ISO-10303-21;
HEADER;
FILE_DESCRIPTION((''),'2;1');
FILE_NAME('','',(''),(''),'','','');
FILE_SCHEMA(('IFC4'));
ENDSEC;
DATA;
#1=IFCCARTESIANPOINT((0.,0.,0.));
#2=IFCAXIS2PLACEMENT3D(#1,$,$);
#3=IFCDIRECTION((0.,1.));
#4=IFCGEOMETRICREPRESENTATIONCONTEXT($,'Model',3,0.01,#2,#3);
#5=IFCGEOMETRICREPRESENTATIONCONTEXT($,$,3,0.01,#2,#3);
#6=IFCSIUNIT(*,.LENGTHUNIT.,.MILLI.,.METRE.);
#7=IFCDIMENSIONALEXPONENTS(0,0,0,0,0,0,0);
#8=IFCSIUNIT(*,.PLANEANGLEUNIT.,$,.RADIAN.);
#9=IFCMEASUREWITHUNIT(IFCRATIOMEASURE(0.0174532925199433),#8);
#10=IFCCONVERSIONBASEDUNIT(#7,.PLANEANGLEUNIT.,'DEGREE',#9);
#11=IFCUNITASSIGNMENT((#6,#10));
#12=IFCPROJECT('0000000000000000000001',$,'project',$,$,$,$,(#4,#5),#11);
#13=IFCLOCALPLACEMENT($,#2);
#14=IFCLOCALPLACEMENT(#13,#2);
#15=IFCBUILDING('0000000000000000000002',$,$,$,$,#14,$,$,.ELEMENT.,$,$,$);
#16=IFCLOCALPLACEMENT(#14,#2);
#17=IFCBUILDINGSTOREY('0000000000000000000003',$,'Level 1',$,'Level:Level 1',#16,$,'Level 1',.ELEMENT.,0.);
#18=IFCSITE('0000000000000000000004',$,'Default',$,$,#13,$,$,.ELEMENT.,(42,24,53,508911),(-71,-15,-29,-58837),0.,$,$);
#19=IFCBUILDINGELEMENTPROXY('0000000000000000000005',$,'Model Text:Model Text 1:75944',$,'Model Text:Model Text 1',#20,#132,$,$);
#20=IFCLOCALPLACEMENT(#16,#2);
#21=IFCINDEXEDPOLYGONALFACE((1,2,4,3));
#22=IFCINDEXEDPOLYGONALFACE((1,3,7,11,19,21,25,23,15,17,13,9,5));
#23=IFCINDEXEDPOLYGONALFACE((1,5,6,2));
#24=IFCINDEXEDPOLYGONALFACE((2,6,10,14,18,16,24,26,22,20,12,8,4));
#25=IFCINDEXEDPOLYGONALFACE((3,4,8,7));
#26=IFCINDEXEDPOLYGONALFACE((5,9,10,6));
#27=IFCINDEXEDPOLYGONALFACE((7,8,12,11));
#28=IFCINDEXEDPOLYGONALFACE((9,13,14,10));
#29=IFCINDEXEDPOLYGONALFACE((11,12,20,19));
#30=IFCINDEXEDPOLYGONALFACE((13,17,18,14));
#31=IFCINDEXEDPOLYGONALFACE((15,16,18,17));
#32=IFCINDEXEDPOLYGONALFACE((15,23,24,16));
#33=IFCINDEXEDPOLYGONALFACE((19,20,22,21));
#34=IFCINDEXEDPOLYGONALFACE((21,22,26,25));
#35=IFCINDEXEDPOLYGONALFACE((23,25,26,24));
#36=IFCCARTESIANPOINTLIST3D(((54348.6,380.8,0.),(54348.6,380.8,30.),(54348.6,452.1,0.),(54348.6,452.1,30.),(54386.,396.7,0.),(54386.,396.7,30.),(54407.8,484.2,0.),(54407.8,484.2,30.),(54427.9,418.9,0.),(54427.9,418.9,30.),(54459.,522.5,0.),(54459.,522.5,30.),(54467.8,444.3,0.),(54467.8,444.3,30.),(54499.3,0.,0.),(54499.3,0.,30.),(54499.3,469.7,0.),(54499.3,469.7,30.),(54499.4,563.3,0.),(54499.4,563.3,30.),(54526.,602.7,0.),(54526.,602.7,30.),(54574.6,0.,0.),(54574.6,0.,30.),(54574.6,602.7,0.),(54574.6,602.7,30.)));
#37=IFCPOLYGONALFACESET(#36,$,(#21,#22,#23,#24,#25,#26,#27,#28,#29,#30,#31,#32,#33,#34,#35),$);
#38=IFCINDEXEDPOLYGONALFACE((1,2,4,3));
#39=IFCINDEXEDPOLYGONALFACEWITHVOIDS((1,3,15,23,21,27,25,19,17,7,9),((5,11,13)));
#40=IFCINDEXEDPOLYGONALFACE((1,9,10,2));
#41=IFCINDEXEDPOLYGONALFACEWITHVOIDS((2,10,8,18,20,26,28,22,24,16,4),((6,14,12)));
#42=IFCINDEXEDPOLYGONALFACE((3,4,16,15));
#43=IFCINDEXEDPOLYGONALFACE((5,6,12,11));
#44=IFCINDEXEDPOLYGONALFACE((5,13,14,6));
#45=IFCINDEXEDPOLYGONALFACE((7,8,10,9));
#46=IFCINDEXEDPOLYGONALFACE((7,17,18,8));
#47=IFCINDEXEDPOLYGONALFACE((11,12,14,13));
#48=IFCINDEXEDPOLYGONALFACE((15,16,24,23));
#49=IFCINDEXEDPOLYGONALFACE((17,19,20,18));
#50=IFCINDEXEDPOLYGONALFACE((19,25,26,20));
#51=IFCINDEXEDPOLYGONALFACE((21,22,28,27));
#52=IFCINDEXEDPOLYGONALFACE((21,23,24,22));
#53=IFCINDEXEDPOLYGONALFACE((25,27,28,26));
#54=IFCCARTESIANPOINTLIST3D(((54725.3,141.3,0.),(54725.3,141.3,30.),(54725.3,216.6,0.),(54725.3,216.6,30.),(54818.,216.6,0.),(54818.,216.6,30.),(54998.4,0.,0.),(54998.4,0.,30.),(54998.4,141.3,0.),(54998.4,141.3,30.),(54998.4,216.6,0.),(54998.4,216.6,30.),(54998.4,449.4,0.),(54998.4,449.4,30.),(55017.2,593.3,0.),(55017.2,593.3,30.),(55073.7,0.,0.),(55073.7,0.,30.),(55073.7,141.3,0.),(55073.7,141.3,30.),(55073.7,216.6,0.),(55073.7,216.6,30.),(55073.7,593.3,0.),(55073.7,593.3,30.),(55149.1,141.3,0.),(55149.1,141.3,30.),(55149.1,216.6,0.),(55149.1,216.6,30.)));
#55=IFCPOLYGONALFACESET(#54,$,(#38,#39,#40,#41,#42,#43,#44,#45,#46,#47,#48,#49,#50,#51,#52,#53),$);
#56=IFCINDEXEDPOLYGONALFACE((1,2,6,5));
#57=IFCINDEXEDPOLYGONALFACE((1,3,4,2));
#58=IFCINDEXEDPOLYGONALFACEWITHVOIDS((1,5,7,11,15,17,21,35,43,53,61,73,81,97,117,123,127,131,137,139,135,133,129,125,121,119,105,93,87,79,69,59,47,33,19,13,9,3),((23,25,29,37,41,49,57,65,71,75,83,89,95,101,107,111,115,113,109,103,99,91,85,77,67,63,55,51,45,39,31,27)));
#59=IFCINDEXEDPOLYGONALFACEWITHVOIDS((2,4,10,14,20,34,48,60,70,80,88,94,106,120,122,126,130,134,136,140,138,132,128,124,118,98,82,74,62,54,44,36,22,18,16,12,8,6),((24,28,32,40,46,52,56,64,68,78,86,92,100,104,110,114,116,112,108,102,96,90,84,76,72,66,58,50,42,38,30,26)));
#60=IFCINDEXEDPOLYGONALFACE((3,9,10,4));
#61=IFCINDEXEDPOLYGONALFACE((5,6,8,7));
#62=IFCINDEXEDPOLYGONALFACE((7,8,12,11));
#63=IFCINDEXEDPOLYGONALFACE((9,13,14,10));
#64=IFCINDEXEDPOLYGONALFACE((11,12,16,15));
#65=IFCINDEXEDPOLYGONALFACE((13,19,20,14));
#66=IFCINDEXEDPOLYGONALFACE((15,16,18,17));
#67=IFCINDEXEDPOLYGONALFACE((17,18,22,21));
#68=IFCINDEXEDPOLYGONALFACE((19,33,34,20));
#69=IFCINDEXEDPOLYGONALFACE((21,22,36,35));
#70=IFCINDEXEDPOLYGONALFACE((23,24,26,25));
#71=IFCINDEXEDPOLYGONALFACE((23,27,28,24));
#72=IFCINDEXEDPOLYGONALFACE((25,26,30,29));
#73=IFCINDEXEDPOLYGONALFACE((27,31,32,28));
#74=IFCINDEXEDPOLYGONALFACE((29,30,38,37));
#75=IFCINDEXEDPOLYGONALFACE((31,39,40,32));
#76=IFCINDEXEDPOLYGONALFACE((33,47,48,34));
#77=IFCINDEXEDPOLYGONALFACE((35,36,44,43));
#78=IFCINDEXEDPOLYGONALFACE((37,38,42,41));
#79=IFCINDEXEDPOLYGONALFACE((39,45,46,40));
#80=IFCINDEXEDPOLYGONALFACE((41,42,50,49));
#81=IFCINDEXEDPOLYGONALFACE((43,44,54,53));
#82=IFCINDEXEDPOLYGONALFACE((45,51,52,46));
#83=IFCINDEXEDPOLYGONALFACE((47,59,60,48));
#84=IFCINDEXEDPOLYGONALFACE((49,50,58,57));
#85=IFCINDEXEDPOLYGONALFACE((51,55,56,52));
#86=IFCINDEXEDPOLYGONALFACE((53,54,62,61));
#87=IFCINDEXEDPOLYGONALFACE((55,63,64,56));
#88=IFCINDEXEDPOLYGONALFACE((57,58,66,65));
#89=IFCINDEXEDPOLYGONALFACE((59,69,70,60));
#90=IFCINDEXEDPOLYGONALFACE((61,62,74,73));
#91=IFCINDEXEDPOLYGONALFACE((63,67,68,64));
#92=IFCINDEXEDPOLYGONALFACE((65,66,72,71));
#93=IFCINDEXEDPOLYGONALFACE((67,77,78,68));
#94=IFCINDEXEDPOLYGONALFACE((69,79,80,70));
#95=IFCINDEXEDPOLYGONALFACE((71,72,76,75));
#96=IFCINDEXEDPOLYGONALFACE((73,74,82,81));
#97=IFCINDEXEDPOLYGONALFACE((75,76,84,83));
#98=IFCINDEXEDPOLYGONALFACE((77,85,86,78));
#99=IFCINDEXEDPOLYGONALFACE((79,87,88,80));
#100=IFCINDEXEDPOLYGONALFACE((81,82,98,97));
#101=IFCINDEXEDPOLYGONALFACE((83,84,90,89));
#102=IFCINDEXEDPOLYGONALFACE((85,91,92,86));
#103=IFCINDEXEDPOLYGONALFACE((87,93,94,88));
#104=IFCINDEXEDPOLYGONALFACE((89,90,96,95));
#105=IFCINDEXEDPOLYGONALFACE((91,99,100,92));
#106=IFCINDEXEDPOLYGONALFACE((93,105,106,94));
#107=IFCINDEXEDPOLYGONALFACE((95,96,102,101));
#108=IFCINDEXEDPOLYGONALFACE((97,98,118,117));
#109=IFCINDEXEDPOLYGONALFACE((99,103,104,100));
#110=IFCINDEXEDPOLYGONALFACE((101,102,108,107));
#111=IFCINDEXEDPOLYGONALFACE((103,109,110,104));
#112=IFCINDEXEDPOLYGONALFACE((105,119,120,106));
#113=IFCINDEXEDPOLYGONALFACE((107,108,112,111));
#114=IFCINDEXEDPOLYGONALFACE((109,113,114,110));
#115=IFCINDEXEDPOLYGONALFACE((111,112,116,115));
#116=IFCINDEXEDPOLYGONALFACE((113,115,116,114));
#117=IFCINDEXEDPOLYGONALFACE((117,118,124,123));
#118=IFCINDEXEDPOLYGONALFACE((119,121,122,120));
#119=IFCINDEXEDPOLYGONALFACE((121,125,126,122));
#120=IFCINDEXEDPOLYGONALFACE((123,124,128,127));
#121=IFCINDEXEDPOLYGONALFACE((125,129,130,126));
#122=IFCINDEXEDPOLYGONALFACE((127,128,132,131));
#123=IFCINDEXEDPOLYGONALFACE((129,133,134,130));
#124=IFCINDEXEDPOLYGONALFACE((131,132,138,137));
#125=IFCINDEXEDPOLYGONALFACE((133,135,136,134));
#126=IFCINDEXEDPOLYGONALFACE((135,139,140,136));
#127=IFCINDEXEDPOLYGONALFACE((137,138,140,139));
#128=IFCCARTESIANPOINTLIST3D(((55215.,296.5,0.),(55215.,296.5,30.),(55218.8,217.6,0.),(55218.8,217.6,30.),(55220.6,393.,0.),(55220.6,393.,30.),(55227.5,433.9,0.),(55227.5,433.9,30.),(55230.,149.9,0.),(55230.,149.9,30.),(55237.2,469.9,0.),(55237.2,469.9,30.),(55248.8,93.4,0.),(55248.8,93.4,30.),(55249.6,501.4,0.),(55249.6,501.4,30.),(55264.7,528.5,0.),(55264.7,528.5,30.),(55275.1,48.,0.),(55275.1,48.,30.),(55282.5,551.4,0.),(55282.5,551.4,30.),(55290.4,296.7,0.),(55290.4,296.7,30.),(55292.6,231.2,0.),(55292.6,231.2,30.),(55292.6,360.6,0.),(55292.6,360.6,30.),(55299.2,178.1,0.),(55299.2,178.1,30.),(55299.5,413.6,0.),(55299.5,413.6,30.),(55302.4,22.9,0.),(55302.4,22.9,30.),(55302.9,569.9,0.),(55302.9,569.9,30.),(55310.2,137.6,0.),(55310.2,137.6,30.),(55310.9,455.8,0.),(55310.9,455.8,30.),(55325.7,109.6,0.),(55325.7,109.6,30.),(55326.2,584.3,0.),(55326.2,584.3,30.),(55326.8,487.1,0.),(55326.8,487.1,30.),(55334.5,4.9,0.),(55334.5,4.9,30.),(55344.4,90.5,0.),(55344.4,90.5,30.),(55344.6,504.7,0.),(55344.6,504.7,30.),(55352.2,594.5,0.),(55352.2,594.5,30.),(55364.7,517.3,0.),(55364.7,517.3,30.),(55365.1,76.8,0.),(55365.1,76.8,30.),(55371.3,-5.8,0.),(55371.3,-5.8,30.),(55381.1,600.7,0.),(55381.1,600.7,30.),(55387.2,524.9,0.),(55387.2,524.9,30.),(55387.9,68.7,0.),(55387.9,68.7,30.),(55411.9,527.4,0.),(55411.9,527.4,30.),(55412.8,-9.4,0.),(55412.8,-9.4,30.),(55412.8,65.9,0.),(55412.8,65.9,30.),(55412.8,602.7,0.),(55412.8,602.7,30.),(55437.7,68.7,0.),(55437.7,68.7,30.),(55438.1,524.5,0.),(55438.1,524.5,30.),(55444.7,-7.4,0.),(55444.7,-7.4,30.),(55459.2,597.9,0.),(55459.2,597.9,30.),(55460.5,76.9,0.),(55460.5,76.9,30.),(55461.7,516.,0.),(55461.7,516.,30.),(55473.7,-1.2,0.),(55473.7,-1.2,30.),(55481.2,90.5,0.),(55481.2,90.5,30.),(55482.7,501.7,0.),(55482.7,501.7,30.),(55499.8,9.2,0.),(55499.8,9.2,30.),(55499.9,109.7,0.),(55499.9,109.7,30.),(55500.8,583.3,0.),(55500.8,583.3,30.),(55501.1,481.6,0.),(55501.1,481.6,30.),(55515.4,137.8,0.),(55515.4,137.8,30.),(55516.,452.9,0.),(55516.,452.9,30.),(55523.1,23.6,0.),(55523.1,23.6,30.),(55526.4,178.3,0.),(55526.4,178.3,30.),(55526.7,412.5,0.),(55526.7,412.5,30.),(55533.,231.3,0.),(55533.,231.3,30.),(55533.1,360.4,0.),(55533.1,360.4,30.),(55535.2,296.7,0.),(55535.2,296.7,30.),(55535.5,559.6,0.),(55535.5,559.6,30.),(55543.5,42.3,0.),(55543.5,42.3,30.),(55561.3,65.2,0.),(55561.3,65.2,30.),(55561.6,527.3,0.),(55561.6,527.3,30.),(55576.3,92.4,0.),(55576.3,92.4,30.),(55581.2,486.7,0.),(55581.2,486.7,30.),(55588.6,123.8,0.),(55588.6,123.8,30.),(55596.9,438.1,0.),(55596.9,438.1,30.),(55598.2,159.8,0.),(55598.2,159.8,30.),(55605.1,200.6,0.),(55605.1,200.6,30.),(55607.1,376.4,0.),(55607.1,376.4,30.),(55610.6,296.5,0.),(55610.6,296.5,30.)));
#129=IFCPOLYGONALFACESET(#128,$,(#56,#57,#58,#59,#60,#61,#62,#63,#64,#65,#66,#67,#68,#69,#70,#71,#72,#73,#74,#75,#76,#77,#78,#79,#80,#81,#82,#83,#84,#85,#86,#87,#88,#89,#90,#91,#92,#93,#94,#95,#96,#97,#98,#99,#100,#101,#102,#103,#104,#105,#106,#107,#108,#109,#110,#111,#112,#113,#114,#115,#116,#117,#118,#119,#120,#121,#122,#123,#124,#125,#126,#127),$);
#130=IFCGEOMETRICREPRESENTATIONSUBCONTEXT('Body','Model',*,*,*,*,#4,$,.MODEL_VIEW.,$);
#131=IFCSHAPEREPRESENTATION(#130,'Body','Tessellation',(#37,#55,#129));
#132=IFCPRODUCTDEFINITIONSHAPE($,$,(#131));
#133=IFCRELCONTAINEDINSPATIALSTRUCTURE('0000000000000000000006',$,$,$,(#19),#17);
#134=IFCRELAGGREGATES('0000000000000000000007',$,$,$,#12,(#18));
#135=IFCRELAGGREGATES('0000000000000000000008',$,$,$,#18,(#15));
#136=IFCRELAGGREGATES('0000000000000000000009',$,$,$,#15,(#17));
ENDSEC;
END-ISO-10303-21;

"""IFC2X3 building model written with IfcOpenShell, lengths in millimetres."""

from ifc_helpers import new_model, entity, si_unit, converted_unit, direction, frame, origin, place, context, subcontext, project, spatial, polyline, outline, extrude, element, save


model = new_model("IFC2X3")

# Units and contexts
model_context = context("Model", 3, precision=0.01, world=origin(), true_north=direction((0.0, 1.0)))
context_of_model = context(None, 3, precision=0.01, world=origin(), true_north=direction((0.0, 1.0)))
body_context = subcontext(model_context, "Body", "Model", "MODEL_VIEW")
ifc_project = project(units=[si_unit("LENGTHUNIT", "METRE", prefix="MILLI"), converted_unit("PLANEANGLEUNIT", "DEGREE", entity("IfcRatioMeasure", 0.0174532925199433), si_unit("PLANEANGLEUNIT", "RADIAN"), dimensions=[0, 0, 0, 0, 0, 0, 0])], contexts=[model_context, context_of_model])

# Site, building, storey
site_placement = place(None, origin())
site = spatial("IfcSite", under=ifc_project, at=site_placement, Name="Default", CompositionType="ELEMENT", RefLatitude=(42, 24, 53, 508911), RefLongitude=(-71, -15, -29, -58837), RefElevation=0.0)
building_placement = place(site_placement, origin())
building = spatial("IfcBuilding", under=site, at=building_placement, CompositionType="ELEMENT")
storey_placement = place(building_placement, origin())
storey = spatial("IfcBuildingStorey", under=building, at=storey_placement, Name="Level 1", ObjectType="Level:Level 1", LongName="Level 1", CompositionType="ELEMENT", Elevation=0.0)

# Building element proxy
proxy_1_placement = place(storey_placement, origin())
element("IfcBuildingElementProxy", 1, at=proxy_1_placement, inside=storey, Name="Model Text:Model Text 1:75944", ObjectType="Model Text:Model Text 1", context=body_context, shape_type="SweptSolid", body=[
    extrude(outline(polyline([(-410.6, -111.6), (192.1, -111.6), (192.1, -63.1), (152.7, -36.4), (111.9, 4.0), (73.6, 55.2), (41.4, 114.4), (-29.8, 114.4), (-13.9, 77.0), (8.3, 35.1), (33.7, -4.8), (59.1, -36.3), (-410.6, -36.3), (-410.6, -111.6)])), frame((54463.0, 410.6, 0.0), z_axis=(0.0, 0.0, 1.0), x_axis=(0.0, 1.0, 0.0)), (0.0, 0.0, 1.0), 30.0),
    extrude(outline(polyline([(-6.8, -218.3), (68.5, -218.3), (68.5, -77.1), (143.8, -77.1), (143.8, -1.7), (68.5, -1.7), (68.5, 375.0), (12.0, 375.0), (-280.0, -1.7), (-280.0, -77.1), (-6.8, -77.1), (-6.8, -218.3)]), holes=[polyline([(-6.8, -1.7), (-187.3, -1.7), (-6.8, 231.1), (-6.8, -1.7)])]), frame((55005.3, 218.3, 0.0)), (0.0, 0.0, 1.0), 30.0),
    extrude(outline(polyline([(-10.6, -198.7), (68.3, -198.7), (136.5, -190.7), (193.9, -174.7), (240.5, -150.6), (266.9, -124.4), (286.3, -93.2), (298.8, -57.0), (304.3, -15.7), (303.8, 16.2), (299.0, 45.5), (289.9, 72.1), (276.6, 96.0), (258.9, 117.3), (236.9, 136.2), (210.4, 152.5), (179.6, 166.3), (144.1, 177.6), (103.7, 186.3), (8.2, 196.4), (-71.8, 196.7), (-134.0, 189.4), (-183.3, 176.1), (-224.7, 158.4), (-258.2, 133.9), (-283.5, 100.3), (-300.1, 59.5), (-307.1, 13.4), (-306.6, -18.4), (-301.8, -47.5), (-292.8, -74.0), (-279.6, -97.9), (-262.0, -119.2), (-240.0, -138.1), (-213.6, -154.5), (-182.8, -168.4), (-147.3, -179.8), (-106.7, -188.6), (-10.6, -198.7)]), holes=[polyline([(-7.2, -123.5), (-71.0, -118.2), (-123.6, -108.8), (-165.2, -95.4), (-195.7, -78.0), (-212.4, -59.4), (-224.1, -38.7), (-230.6, -15.9), (-231.9, 8.9), (-227.8, 35.0), (-218.1, 58.1), (-202.8, 78.4), (-182.0, 95.8), (-152.6, 109.4), (-111.7, 118.1), (-59.4, 122.0), (4.4, 121.1), (69.6, 115.8), (122.2, 106.7), (162.2, 93.7), (189.5, 77.0), (207.7, 57.4), (220.4, 36.0), (227.5, 12.8), (229.1, -12.1), (225.2, -36.8), (215.9, -59.2), (201.3, -79.3), (181.4, -97.1), (152.6, -111.2), (111.6, -120.3), (58.3, -124.4), (-7.2, -123.5)])]), frame((55414.0, 295.3, 0.0), z_axis=(0.0, 0.0, 1.0), x_axis=(0.047515, -0.998871, 0.0)), (0.0, 0.0, 1.0), 30.0),
])

save(model, "model.ifc")
